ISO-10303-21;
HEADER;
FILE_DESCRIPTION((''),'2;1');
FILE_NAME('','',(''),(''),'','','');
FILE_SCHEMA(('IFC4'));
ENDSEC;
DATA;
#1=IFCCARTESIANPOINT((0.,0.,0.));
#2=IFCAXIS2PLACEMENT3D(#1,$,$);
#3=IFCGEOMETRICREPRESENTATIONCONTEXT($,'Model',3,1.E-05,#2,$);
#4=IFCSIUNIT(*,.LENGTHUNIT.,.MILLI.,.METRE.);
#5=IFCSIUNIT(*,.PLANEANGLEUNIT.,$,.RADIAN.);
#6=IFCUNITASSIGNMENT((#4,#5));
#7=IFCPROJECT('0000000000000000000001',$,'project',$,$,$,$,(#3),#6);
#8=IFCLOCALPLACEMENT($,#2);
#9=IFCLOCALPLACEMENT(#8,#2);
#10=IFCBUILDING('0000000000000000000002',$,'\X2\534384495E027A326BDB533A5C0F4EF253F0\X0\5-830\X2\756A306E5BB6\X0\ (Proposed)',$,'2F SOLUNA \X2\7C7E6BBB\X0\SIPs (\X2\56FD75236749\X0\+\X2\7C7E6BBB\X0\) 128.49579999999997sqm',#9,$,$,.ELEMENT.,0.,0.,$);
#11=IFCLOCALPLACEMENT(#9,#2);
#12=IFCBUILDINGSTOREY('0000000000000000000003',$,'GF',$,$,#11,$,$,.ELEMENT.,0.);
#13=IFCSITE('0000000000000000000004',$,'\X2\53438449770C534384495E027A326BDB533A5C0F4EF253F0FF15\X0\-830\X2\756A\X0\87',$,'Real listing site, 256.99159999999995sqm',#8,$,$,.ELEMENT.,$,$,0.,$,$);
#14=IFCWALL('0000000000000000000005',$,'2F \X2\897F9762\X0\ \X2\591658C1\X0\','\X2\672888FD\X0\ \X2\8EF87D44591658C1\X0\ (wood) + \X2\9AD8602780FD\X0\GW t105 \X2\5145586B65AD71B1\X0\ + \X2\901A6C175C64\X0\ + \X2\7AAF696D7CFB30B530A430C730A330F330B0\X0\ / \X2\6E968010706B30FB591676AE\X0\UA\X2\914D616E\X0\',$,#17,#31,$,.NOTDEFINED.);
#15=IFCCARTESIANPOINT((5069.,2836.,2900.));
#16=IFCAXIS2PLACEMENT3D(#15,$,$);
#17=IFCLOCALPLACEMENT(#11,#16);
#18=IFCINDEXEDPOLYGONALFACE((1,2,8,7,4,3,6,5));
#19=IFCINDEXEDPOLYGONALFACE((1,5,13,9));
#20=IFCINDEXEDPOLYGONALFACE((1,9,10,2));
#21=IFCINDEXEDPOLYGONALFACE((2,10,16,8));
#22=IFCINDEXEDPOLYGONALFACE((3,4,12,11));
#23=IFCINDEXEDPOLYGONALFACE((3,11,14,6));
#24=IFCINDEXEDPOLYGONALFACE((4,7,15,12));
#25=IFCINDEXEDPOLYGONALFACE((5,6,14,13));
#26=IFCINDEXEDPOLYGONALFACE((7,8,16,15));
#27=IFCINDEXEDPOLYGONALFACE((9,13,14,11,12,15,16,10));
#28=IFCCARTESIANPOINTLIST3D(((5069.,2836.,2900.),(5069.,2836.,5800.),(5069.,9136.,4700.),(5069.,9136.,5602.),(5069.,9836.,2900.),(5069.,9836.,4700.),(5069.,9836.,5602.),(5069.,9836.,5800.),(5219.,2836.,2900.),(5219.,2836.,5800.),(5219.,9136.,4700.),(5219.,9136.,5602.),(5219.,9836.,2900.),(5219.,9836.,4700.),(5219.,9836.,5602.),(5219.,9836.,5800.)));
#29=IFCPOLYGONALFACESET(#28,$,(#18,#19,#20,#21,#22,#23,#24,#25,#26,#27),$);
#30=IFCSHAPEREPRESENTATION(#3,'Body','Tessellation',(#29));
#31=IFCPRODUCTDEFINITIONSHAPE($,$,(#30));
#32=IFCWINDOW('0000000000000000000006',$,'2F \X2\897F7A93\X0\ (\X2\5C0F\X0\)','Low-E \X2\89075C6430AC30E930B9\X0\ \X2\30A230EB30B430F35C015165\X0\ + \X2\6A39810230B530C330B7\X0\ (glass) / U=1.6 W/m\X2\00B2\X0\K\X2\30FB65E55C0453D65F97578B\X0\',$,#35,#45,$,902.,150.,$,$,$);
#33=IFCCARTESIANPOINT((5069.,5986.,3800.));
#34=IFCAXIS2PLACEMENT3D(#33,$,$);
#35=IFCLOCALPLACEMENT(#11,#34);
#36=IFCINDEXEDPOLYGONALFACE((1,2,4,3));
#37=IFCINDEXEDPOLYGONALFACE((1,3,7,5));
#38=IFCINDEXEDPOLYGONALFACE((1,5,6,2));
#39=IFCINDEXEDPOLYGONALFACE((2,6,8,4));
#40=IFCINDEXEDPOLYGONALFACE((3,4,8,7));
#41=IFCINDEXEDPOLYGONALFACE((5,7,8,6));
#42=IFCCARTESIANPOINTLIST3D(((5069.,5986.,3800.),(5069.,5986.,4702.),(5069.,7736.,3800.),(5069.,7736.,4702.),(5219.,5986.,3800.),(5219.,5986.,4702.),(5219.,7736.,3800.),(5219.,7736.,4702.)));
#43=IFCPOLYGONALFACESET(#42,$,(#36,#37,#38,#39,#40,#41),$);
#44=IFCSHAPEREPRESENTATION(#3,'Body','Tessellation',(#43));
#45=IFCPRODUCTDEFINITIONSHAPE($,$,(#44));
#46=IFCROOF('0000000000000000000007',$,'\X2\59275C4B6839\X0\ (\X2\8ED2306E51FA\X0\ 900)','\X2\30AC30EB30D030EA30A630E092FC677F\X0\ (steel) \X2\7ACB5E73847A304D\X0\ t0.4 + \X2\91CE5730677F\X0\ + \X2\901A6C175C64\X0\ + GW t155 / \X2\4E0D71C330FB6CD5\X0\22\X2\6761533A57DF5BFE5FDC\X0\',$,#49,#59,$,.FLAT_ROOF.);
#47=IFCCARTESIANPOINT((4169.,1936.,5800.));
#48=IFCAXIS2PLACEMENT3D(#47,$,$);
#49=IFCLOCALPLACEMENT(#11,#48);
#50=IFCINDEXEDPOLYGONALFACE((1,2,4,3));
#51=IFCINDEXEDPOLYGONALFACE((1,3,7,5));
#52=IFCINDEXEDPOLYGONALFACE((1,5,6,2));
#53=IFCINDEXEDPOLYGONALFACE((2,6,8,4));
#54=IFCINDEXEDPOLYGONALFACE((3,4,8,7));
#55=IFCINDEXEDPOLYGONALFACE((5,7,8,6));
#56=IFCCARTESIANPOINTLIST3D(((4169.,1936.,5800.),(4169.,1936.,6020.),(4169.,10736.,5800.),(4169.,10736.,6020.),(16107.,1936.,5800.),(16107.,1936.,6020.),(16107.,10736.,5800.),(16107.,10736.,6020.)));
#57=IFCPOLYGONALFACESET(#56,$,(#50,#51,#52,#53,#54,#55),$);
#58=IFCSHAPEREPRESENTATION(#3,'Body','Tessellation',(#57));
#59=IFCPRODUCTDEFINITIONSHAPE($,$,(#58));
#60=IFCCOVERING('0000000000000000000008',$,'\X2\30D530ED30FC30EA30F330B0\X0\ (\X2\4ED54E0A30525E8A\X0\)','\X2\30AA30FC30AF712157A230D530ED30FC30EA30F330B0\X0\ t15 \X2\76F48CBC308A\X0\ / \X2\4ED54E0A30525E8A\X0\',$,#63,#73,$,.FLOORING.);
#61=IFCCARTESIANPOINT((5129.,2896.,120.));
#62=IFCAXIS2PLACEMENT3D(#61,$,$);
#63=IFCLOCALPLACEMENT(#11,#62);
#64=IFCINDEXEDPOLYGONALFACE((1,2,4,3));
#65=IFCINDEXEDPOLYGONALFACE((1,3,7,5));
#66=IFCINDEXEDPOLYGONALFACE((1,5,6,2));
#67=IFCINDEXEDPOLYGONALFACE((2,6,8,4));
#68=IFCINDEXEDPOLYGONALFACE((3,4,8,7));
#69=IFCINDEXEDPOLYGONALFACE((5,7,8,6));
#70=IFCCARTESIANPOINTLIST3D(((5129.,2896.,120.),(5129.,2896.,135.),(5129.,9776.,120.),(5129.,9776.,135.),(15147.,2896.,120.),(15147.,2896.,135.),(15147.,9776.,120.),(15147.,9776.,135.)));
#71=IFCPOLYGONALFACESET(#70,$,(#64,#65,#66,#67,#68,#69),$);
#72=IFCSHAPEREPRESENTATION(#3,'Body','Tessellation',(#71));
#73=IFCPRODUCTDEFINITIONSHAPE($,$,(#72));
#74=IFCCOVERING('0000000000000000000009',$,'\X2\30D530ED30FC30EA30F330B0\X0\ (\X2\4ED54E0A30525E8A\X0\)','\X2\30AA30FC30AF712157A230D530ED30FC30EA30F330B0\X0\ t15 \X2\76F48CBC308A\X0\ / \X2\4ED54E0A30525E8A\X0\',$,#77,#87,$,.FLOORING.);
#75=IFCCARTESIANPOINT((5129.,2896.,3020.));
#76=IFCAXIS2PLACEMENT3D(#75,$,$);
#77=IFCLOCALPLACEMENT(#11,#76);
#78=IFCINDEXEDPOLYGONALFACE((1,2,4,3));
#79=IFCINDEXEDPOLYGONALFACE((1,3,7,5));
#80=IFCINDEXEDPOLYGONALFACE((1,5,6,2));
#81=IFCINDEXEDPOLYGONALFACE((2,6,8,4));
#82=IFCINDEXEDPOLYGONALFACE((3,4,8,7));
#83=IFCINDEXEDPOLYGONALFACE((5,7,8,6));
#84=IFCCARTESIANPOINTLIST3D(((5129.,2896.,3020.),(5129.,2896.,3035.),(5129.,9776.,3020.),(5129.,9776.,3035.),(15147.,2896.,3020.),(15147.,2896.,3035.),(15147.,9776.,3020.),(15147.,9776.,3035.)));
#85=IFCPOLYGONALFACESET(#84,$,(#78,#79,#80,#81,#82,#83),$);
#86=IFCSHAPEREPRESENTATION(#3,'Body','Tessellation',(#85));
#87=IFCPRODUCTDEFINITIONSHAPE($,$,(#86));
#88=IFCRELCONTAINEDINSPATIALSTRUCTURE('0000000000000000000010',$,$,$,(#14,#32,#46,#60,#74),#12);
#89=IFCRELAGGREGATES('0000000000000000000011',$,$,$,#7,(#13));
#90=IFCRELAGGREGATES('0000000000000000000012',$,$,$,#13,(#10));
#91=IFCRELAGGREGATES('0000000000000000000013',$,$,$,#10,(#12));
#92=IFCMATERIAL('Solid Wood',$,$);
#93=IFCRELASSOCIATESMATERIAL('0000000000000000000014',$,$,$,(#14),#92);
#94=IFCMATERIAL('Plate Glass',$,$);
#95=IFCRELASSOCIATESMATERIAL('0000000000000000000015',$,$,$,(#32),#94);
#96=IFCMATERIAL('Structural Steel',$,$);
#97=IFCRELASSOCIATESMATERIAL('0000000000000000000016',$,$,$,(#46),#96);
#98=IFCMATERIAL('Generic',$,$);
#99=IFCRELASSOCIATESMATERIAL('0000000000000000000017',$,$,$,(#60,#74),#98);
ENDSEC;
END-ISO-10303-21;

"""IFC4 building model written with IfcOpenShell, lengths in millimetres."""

from ifc_helpers import new_model, si_unit, frame, frame_2d, origin, place, context, project, spatial, rectangle, extrude, material, element, fill, save


model = new_model("IFC4")

# Units and contexts
model_context = context("Model", 3, precision=1e-05, world=origin())
ifc_project = project(units=[si_unit("LENGTHUNIT", "METRE", prefix="MILLI"), si_unit("PLANEANGLEUNIT", "RADIAN")], contexts=[model_context])

# Site, building, storey
site_placement = place(None, origin())
site = spatial("IfcSite", under=ifc_project, at=site_placement, Name="千葉県千葉市稲毛区小仲台５-830番87", ObjectType="Real listing site, 256.99159999999995sqm", CompositionType="ELEMENT", RefElevation=0.0)
building_placement = place(site_placement, origin())
building = spatial("IfcBuilding", under=site, at=building_placement, Name="千葉市稲毛区小仲台5-830番の家 (Proposed)", ObjectType="2F SOLUNA 籾殻SIPs (国産杉+籾殻) 128.49579999999997sqm", CompositionType="ELEMENT", ElevationOfRefHeight=0.0, ElevationOfTerrain=0.0)
storey_placement = place(building_placement, origin())
storey = spatial("IfcBuildingStorey", under=building, at=storey_placement, Name="GF", CompositionType="ELEMENT", Elevation=0.0)

# Shared definitions
ifc_material_1 = material(Name="Solid Wood")

# Shared definitions
ifc_material_2 = material(Name="Plate Glass")

# Wall, opening, window
wall_1_placement = place(storey_placement, frame((5069.0, 2836.0, 2900.0)))
wall_1 = element("IfcWall", 1, at=wall_1_placement, inside=storey, material=ifc_material_1, Name="2F 西面 外壁", Description="木製 軸組外壁 (wood) + 高性能GW t105 充填断熱 + 通気層 + 窯業系サイディング / 準耐火・外皮UA配慮", PredefinedType="NOTDEFINED", context=model_context, shape_type="SweptSolid", body=[
    extrude(rectangle(XDim=150.0, YDim=7000.0, at=frame_2d((75.0, 3500.0))), frame((5069.0, 2836.0, 2900.0)), (0.0, 0.0, 1.0), 2900.0),
])
opening_1_placement = place(storey_placement, frame((5069.0, 5986.0, 3800.0)))
opening_1 = element("IfcOpeningElement", 2, at=opening_1_placement, cuts=wall_1, PredefinedType="NOTDEFINED", context=model_context, shape_type="SweptSolid", body=[
    extrude(rectangle(XDim=150.0, YDim=1750.0, at=frame_2d((75.0, 875.0))), frame((5069.0, 5986.0, 3800.0)), (0.0, 0.0, 1.0), 902.0),
])
window_1_placement = place(storey_placement, frame((5069.0, 5986.0, 3800.0)))
window_1 = element("IfcWindow", 3, at=window_1_placement, inside=storey, material=ifc_material_2, Name="2F 西窓 (小)", Description="Low-E 複層ガラス アルゴン封入 + 樹脂サッシ (glass) / U=1.6 W/m²K・日射取得型", OverallHeight=902.0, OverallWidth=150.0, context=model_context, shape_type="SweptSolid", body=[
    extrude(rectangle(XDim=150.0, YDim=1750.0, at=frame_2d((75.0, 875.0))), frame((5069.0, 5986.0, 3800.0)), (0.0, 0.0, 1.0), 902.0),
])
fill(opening_1, window_1)

# Roof
ifc_material_3 = material(Name="Structural Steel")
roof_placement = place(storey_placement, frame((4169.0, 1936.0, 5800.0)))
element("IfcRoof", 4, at=roof_placement, inside=storey, material=ifc_material_3, Name="大屋根 (軒の出 900)", Description="ガルバリウム鋼板 (steel) 立平葺き t0.4 + 野地板 + 通気層 + GW t155 / 不燃・法22条区域対応", PredefinedType="FLAT_ROOF", context=model_context, shape_type="SweptSolid", body=[
    extrude(rectangle(XDim=11938.0, YDim=8800.0, at=frame_2d((5969.0, 4400.0))), frame((4169.0, 1936.0, 5800.0)), (0.0, 0.0, 1.0), 220.0),
])

# Coverings
ifc_material_4 = material(Name="Generic")
covering_1_placement = place(storey_placement, frame((5129.0, 2896.0, 120.0)))
element("IfcCovering", 5, at=covering_1_placement, inside=storey, material=ifc_material_4, Name="フローリング (仕上げ床)", Description="オーク無垢フローリング t15 直貼り / 仕上げ床", PredefinedType="FLOORING", context=model_context, shape_type="SweptSolid", body=[
    extrude(rectangle(XDim=10018.0, YDim=6880.0, at=frame_2d((5009.0, 3440.0))), frame((5129.0, 2896.0, 120.0)), (0.0, 0.0, 1.0), 15.0),
])
covering_2_placement = place(storey_placement, frame((5129.0, 2896.0, 3020.0)))
element("IfcCovering", 6, at=covering_2_placement, inside=storey, material=ifc_material_4, Name="フローリング (仕上げ床)", Description="オーク無垢フローリング t15 直貼り / 仕上げ床", PredefinedType="FLOORING", context=model_context, shape_type="SweptSolid", body=[
    extrude(rectangle(XDim=10018.0, YDim=6880.0, at=frame_2d((5009.0, 3440.0))), frame((5129.0, 2896.0, 3020.0)), (0.0, 0.0, 1.0), 15.0),
])

save(model, "model.ifc")
